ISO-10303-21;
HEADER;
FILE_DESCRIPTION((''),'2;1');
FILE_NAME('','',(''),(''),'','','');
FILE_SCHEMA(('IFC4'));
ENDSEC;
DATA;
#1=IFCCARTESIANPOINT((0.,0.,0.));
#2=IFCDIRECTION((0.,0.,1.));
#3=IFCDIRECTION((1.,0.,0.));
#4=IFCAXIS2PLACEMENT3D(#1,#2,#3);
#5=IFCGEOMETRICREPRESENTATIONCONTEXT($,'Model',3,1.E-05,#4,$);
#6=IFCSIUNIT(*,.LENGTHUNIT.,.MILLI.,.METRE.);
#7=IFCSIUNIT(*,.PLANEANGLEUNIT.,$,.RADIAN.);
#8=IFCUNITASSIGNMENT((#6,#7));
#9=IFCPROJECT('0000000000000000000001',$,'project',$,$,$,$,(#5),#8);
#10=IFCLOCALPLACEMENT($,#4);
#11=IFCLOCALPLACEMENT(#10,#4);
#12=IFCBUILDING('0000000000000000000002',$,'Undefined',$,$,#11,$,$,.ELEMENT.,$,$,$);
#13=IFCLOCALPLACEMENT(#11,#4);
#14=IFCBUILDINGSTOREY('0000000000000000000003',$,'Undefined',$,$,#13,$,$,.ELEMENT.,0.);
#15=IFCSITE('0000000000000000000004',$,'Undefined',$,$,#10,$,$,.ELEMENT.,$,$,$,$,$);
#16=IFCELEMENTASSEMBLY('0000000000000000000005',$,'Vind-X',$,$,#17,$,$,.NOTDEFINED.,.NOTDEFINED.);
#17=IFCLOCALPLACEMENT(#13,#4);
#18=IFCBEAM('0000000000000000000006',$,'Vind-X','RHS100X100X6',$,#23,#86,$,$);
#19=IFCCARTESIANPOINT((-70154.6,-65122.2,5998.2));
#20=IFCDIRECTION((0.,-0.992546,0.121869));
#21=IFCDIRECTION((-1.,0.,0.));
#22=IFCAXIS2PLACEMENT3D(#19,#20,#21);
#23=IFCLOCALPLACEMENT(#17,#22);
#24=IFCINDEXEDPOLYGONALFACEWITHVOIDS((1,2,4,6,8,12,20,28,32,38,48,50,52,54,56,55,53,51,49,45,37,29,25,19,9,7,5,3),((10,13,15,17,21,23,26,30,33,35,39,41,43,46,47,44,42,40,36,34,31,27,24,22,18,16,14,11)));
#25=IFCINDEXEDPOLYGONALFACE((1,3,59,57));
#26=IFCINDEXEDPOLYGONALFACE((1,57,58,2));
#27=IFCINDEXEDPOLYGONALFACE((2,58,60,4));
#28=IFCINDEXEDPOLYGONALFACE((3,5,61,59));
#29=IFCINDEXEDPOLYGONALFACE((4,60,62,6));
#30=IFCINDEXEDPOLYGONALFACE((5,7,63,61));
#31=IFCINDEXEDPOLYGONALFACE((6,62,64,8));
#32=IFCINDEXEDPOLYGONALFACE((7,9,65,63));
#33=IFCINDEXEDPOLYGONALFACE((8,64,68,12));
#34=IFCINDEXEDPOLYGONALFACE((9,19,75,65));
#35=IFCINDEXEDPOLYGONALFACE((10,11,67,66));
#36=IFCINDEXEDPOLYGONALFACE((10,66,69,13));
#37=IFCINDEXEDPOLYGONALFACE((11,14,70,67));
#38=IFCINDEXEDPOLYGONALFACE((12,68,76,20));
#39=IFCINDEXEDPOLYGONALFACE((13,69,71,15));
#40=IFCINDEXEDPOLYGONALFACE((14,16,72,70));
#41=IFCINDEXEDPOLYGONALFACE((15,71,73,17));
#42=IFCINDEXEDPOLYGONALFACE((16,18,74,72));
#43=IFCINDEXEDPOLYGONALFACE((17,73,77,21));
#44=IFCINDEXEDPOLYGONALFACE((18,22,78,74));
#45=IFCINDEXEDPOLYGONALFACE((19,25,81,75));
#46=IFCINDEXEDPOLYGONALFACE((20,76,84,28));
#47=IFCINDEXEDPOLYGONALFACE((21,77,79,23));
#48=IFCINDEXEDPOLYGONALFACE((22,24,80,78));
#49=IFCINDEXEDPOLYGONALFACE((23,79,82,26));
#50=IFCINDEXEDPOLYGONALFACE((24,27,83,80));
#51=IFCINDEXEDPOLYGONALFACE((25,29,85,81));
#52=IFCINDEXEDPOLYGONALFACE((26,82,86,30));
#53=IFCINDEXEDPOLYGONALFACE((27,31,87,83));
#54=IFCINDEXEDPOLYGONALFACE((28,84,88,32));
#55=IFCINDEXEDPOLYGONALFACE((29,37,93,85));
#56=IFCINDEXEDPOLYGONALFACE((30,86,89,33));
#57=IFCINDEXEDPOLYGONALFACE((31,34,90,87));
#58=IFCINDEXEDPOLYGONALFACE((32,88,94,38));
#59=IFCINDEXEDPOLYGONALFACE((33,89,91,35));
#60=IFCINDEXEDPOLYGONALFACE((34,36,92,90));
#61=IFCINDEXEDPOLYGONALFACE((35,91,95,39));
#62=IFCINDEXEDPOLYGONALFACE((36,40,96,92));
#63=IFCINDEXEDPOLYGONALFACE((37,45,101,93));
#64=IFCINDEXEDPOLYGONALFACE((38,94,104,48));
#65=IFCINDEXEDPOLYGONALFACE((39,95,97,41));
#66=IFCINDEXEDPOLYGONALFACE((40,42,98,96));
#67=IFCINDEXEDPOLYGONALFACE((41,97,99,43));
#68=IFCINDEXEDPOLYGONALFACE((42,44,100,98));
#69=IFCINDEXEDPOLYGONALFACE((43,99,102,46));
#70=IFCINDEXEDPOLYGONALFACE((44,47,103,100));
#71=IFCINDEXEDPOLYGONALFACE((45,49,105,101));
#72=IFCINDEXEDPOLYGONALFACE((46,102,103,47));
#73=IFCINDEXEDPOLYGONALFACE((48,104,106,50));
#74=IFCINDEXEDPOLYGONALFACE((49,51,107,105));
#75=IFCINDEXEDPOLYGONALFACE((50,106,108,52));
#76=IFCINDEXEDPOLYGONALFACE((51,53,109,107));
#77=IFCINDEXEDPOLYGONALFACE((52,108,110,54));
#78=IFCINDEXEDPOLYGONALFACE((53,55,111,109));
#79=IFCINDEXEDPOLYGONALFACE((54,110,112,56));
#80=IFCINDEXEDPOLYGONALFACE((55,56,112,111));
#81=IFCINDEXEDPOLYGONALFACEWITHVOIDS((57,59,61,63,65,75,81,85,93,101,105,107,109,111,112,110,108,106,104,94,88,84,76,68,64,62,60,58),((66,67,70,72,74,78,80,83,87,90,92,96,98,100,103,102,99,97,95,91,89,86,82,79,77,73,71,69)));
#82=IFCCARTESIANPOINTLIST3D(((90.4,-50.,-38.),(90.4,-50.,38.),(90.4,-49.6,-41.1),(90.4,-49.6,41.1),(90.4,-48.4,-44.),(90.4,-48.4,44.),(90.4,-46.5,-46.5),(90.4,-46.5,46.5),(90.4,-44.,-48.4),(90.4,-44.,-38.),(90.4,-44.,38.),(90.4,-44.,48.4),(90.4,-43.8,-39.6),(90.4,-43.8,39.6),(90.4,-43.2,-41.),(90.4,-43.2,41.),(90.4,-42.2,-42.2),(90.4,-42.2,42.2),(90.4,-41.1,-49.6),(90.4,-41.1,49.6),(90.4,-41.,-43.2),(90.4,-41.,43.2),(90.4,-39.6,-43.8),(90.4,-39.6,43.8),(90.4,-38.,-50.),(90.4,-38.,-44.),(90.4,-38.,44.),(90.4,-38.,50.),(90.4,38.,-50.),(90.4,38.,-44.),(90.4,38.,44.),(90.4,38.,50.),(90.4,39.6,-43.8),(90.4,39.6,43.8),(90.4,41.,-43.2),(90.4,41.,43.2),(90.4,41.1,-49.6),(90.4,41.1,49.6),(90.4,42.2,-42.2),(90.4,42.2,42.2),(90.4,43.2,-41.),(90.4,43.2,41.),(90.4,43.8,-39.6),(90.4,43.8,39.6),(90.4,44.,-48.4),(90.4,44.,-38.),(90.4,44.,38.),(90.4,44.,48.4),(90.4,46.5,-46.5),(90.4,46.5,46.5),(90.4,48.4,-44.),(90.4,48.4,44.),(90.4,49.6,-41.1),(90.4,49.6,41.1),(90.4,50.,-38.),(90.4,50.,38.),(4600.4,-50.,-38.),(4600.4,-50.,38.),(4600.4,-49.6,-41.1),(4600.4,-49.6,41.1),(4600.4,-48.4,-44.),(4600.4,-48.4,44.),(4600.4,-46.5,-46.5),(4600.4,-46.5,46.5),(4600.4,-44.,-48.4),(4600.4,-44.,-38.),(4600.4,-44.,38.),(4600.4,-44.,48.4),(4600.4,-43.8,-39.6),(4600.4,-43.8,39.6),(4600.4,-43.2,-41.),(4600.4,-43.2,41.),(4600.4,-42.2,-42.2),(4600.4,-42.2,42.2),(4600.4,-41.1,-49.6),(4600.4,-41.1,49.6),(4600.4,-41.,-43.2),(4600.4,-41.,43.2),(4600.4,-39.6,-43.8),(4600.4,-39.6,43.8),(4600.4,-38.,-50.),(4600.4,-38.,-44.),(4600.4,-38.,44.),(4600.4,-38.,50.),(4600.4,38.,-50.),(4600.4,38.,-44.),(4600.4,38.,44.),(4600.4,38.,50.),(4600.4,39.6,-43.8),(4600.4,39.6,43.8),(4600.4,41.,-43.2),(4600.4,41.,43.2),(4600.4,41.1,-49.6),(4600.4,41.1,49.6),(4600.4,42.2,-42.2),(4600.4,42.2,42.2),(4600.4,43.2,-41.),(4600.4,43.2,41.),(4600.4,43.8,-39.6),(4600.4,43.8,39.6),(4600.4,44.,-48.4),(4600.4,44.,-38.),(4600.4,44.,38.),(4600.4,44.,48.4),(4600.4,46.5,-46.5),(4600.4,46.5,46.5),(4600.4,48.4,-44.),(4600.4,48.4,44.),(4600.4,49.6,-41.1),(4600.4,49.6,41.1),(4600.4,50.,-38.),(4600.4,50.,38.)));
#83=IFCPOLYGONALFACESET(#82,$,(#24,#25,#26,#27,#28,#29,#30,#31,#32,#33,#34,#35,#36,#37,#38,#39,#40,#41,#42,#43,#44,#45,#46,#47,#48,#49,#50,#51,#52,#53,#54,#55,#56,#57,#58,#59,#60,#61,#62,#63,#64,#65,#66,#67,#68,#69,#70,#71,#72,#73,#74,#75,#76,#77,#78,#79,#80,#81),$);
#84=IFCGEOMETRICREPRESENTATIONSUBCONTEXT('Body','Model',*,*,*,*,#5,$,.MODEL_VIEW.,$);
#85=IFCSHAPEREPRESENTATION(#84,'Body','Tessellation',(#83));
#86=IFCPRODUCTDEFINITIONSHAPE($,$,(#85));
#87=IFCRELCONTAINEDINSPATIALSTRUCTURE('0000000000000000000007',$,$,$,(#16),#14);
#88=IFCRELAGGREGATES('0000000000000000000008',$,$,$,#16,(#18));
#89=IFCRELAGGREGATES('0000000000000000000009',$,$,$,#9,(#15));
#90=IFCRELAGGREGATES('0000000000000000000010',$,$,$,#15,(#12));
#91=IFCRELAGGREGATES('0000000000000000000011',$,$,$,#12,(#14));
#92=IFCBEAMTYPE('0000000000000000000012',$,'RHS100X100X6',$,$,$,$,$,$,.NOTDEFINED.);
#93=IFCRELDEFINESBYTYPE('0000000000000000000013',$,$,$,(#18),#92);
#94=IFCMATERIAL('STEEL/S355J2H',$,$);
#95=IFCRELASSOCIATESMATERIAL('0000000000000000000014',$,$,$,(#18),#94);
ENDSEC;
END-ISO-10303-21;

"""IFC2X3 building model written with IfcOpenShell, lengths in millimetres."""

from ifc_helpers import new_model, si_unit, frame, origin_with_axes, origin_2d_with_axis, place, context, subcontext, project, spatial, hollow_rectangle, extrude, clip, halfspace, material, type_object, element, aggregate, save


model = new_model("IFC2X3")

# Units and contexts
model_context = context("Model", 3, precision=1e-05, world=origin_with_axes())
body_context = subcontext(model_context, "Body", "Model", "MODEL_VIEW")
ifc_project = project(units=[si_unit("LENGTHUNIT", "METRE", prefix="MILLI"), si_unit("PLANEANGLEUNIT", "RADIAN")], contexts=[model_context])

# Site, building, storey
site_placement = place(None, origin_with_axes())
site = spatial("IfcSite", under=ifc_project, at=site_placement, Name="Undefined", CompositionType="ELEMENT")
building_placement = place(site_placement, origin_with_axes())
building = spatial("IfcBuilding", under=site, at=building_placement, Name="Undefined", CompositionType="ELEMENT")
storey_placement = place(building_placement, origin_with_axes())
storey = spatial("IfcBuildingStorey", under=building, at=storey_placement, Name="Undefined", CompositionType="ELEMENT", Elevation=0.0)

# Shared definitions
ifc_material_1 = material(Name="STEEL/S355J2H")

# Element assembly, beam
assembly_1_placement = place(storey_placement, origin_with_axes())
assembly_1 = element("IfcElementAssembly", 1, at=assembly_1_placement, inside=storey, Name="Vind-X", AssemblyPlace="NOTDEFINED", PredefinedType="NOTDEFINED")
beam_type_1 = type_object("IfcBeamType", Name="RHS100X100X6", PredefinedType="NOTDEFINED")
beam_1_placement = place(assembly_1_placement, frame((-70154.6, -65122.2, 5998.2), z_axis=(0.0, -0.992546, 0.121869), x_axis=(-1.0, 0.0, 0.0)))
beam_1 = element("IfcBeam", 2, at=beam_1_placement, type_object=beam_type_1, material=ifc_material_1, Name="Vind-X", Description="RHS100X100X6", context=body_context, shape_type="Clipping", body=[
    clip(clip(extrude(hollow_rectangle(XDim=100.0, YDim=100.0, WallThickness=6.0, InnerFilletRadius=6.0, OuterFilletRadius=12.0, at=origin_2d_with_axis()), frame((4690.0, 0.0, 0.0), z_axis=(-1.0, 0.0, 0.0), x_axis=(0.0, -1.0, 0.0)), (0.0, 0.0, 1.0), 4690.0), halfspace(frame((4600.4, 22.5, 0.0), z_axis=(-1.0, 0.0, 0.0), x_axis=(0.0, 0.0, 1.0)), True)), halfspace(frame((90.4, 22.5, 0.0), z_axis=(1.0, 0.0, 0.0), x_axis=(0.0, 0.0, -1.0)), True)),
])

aggregate(assembly_1, [beam_1])

save(model, "model.ifc")
